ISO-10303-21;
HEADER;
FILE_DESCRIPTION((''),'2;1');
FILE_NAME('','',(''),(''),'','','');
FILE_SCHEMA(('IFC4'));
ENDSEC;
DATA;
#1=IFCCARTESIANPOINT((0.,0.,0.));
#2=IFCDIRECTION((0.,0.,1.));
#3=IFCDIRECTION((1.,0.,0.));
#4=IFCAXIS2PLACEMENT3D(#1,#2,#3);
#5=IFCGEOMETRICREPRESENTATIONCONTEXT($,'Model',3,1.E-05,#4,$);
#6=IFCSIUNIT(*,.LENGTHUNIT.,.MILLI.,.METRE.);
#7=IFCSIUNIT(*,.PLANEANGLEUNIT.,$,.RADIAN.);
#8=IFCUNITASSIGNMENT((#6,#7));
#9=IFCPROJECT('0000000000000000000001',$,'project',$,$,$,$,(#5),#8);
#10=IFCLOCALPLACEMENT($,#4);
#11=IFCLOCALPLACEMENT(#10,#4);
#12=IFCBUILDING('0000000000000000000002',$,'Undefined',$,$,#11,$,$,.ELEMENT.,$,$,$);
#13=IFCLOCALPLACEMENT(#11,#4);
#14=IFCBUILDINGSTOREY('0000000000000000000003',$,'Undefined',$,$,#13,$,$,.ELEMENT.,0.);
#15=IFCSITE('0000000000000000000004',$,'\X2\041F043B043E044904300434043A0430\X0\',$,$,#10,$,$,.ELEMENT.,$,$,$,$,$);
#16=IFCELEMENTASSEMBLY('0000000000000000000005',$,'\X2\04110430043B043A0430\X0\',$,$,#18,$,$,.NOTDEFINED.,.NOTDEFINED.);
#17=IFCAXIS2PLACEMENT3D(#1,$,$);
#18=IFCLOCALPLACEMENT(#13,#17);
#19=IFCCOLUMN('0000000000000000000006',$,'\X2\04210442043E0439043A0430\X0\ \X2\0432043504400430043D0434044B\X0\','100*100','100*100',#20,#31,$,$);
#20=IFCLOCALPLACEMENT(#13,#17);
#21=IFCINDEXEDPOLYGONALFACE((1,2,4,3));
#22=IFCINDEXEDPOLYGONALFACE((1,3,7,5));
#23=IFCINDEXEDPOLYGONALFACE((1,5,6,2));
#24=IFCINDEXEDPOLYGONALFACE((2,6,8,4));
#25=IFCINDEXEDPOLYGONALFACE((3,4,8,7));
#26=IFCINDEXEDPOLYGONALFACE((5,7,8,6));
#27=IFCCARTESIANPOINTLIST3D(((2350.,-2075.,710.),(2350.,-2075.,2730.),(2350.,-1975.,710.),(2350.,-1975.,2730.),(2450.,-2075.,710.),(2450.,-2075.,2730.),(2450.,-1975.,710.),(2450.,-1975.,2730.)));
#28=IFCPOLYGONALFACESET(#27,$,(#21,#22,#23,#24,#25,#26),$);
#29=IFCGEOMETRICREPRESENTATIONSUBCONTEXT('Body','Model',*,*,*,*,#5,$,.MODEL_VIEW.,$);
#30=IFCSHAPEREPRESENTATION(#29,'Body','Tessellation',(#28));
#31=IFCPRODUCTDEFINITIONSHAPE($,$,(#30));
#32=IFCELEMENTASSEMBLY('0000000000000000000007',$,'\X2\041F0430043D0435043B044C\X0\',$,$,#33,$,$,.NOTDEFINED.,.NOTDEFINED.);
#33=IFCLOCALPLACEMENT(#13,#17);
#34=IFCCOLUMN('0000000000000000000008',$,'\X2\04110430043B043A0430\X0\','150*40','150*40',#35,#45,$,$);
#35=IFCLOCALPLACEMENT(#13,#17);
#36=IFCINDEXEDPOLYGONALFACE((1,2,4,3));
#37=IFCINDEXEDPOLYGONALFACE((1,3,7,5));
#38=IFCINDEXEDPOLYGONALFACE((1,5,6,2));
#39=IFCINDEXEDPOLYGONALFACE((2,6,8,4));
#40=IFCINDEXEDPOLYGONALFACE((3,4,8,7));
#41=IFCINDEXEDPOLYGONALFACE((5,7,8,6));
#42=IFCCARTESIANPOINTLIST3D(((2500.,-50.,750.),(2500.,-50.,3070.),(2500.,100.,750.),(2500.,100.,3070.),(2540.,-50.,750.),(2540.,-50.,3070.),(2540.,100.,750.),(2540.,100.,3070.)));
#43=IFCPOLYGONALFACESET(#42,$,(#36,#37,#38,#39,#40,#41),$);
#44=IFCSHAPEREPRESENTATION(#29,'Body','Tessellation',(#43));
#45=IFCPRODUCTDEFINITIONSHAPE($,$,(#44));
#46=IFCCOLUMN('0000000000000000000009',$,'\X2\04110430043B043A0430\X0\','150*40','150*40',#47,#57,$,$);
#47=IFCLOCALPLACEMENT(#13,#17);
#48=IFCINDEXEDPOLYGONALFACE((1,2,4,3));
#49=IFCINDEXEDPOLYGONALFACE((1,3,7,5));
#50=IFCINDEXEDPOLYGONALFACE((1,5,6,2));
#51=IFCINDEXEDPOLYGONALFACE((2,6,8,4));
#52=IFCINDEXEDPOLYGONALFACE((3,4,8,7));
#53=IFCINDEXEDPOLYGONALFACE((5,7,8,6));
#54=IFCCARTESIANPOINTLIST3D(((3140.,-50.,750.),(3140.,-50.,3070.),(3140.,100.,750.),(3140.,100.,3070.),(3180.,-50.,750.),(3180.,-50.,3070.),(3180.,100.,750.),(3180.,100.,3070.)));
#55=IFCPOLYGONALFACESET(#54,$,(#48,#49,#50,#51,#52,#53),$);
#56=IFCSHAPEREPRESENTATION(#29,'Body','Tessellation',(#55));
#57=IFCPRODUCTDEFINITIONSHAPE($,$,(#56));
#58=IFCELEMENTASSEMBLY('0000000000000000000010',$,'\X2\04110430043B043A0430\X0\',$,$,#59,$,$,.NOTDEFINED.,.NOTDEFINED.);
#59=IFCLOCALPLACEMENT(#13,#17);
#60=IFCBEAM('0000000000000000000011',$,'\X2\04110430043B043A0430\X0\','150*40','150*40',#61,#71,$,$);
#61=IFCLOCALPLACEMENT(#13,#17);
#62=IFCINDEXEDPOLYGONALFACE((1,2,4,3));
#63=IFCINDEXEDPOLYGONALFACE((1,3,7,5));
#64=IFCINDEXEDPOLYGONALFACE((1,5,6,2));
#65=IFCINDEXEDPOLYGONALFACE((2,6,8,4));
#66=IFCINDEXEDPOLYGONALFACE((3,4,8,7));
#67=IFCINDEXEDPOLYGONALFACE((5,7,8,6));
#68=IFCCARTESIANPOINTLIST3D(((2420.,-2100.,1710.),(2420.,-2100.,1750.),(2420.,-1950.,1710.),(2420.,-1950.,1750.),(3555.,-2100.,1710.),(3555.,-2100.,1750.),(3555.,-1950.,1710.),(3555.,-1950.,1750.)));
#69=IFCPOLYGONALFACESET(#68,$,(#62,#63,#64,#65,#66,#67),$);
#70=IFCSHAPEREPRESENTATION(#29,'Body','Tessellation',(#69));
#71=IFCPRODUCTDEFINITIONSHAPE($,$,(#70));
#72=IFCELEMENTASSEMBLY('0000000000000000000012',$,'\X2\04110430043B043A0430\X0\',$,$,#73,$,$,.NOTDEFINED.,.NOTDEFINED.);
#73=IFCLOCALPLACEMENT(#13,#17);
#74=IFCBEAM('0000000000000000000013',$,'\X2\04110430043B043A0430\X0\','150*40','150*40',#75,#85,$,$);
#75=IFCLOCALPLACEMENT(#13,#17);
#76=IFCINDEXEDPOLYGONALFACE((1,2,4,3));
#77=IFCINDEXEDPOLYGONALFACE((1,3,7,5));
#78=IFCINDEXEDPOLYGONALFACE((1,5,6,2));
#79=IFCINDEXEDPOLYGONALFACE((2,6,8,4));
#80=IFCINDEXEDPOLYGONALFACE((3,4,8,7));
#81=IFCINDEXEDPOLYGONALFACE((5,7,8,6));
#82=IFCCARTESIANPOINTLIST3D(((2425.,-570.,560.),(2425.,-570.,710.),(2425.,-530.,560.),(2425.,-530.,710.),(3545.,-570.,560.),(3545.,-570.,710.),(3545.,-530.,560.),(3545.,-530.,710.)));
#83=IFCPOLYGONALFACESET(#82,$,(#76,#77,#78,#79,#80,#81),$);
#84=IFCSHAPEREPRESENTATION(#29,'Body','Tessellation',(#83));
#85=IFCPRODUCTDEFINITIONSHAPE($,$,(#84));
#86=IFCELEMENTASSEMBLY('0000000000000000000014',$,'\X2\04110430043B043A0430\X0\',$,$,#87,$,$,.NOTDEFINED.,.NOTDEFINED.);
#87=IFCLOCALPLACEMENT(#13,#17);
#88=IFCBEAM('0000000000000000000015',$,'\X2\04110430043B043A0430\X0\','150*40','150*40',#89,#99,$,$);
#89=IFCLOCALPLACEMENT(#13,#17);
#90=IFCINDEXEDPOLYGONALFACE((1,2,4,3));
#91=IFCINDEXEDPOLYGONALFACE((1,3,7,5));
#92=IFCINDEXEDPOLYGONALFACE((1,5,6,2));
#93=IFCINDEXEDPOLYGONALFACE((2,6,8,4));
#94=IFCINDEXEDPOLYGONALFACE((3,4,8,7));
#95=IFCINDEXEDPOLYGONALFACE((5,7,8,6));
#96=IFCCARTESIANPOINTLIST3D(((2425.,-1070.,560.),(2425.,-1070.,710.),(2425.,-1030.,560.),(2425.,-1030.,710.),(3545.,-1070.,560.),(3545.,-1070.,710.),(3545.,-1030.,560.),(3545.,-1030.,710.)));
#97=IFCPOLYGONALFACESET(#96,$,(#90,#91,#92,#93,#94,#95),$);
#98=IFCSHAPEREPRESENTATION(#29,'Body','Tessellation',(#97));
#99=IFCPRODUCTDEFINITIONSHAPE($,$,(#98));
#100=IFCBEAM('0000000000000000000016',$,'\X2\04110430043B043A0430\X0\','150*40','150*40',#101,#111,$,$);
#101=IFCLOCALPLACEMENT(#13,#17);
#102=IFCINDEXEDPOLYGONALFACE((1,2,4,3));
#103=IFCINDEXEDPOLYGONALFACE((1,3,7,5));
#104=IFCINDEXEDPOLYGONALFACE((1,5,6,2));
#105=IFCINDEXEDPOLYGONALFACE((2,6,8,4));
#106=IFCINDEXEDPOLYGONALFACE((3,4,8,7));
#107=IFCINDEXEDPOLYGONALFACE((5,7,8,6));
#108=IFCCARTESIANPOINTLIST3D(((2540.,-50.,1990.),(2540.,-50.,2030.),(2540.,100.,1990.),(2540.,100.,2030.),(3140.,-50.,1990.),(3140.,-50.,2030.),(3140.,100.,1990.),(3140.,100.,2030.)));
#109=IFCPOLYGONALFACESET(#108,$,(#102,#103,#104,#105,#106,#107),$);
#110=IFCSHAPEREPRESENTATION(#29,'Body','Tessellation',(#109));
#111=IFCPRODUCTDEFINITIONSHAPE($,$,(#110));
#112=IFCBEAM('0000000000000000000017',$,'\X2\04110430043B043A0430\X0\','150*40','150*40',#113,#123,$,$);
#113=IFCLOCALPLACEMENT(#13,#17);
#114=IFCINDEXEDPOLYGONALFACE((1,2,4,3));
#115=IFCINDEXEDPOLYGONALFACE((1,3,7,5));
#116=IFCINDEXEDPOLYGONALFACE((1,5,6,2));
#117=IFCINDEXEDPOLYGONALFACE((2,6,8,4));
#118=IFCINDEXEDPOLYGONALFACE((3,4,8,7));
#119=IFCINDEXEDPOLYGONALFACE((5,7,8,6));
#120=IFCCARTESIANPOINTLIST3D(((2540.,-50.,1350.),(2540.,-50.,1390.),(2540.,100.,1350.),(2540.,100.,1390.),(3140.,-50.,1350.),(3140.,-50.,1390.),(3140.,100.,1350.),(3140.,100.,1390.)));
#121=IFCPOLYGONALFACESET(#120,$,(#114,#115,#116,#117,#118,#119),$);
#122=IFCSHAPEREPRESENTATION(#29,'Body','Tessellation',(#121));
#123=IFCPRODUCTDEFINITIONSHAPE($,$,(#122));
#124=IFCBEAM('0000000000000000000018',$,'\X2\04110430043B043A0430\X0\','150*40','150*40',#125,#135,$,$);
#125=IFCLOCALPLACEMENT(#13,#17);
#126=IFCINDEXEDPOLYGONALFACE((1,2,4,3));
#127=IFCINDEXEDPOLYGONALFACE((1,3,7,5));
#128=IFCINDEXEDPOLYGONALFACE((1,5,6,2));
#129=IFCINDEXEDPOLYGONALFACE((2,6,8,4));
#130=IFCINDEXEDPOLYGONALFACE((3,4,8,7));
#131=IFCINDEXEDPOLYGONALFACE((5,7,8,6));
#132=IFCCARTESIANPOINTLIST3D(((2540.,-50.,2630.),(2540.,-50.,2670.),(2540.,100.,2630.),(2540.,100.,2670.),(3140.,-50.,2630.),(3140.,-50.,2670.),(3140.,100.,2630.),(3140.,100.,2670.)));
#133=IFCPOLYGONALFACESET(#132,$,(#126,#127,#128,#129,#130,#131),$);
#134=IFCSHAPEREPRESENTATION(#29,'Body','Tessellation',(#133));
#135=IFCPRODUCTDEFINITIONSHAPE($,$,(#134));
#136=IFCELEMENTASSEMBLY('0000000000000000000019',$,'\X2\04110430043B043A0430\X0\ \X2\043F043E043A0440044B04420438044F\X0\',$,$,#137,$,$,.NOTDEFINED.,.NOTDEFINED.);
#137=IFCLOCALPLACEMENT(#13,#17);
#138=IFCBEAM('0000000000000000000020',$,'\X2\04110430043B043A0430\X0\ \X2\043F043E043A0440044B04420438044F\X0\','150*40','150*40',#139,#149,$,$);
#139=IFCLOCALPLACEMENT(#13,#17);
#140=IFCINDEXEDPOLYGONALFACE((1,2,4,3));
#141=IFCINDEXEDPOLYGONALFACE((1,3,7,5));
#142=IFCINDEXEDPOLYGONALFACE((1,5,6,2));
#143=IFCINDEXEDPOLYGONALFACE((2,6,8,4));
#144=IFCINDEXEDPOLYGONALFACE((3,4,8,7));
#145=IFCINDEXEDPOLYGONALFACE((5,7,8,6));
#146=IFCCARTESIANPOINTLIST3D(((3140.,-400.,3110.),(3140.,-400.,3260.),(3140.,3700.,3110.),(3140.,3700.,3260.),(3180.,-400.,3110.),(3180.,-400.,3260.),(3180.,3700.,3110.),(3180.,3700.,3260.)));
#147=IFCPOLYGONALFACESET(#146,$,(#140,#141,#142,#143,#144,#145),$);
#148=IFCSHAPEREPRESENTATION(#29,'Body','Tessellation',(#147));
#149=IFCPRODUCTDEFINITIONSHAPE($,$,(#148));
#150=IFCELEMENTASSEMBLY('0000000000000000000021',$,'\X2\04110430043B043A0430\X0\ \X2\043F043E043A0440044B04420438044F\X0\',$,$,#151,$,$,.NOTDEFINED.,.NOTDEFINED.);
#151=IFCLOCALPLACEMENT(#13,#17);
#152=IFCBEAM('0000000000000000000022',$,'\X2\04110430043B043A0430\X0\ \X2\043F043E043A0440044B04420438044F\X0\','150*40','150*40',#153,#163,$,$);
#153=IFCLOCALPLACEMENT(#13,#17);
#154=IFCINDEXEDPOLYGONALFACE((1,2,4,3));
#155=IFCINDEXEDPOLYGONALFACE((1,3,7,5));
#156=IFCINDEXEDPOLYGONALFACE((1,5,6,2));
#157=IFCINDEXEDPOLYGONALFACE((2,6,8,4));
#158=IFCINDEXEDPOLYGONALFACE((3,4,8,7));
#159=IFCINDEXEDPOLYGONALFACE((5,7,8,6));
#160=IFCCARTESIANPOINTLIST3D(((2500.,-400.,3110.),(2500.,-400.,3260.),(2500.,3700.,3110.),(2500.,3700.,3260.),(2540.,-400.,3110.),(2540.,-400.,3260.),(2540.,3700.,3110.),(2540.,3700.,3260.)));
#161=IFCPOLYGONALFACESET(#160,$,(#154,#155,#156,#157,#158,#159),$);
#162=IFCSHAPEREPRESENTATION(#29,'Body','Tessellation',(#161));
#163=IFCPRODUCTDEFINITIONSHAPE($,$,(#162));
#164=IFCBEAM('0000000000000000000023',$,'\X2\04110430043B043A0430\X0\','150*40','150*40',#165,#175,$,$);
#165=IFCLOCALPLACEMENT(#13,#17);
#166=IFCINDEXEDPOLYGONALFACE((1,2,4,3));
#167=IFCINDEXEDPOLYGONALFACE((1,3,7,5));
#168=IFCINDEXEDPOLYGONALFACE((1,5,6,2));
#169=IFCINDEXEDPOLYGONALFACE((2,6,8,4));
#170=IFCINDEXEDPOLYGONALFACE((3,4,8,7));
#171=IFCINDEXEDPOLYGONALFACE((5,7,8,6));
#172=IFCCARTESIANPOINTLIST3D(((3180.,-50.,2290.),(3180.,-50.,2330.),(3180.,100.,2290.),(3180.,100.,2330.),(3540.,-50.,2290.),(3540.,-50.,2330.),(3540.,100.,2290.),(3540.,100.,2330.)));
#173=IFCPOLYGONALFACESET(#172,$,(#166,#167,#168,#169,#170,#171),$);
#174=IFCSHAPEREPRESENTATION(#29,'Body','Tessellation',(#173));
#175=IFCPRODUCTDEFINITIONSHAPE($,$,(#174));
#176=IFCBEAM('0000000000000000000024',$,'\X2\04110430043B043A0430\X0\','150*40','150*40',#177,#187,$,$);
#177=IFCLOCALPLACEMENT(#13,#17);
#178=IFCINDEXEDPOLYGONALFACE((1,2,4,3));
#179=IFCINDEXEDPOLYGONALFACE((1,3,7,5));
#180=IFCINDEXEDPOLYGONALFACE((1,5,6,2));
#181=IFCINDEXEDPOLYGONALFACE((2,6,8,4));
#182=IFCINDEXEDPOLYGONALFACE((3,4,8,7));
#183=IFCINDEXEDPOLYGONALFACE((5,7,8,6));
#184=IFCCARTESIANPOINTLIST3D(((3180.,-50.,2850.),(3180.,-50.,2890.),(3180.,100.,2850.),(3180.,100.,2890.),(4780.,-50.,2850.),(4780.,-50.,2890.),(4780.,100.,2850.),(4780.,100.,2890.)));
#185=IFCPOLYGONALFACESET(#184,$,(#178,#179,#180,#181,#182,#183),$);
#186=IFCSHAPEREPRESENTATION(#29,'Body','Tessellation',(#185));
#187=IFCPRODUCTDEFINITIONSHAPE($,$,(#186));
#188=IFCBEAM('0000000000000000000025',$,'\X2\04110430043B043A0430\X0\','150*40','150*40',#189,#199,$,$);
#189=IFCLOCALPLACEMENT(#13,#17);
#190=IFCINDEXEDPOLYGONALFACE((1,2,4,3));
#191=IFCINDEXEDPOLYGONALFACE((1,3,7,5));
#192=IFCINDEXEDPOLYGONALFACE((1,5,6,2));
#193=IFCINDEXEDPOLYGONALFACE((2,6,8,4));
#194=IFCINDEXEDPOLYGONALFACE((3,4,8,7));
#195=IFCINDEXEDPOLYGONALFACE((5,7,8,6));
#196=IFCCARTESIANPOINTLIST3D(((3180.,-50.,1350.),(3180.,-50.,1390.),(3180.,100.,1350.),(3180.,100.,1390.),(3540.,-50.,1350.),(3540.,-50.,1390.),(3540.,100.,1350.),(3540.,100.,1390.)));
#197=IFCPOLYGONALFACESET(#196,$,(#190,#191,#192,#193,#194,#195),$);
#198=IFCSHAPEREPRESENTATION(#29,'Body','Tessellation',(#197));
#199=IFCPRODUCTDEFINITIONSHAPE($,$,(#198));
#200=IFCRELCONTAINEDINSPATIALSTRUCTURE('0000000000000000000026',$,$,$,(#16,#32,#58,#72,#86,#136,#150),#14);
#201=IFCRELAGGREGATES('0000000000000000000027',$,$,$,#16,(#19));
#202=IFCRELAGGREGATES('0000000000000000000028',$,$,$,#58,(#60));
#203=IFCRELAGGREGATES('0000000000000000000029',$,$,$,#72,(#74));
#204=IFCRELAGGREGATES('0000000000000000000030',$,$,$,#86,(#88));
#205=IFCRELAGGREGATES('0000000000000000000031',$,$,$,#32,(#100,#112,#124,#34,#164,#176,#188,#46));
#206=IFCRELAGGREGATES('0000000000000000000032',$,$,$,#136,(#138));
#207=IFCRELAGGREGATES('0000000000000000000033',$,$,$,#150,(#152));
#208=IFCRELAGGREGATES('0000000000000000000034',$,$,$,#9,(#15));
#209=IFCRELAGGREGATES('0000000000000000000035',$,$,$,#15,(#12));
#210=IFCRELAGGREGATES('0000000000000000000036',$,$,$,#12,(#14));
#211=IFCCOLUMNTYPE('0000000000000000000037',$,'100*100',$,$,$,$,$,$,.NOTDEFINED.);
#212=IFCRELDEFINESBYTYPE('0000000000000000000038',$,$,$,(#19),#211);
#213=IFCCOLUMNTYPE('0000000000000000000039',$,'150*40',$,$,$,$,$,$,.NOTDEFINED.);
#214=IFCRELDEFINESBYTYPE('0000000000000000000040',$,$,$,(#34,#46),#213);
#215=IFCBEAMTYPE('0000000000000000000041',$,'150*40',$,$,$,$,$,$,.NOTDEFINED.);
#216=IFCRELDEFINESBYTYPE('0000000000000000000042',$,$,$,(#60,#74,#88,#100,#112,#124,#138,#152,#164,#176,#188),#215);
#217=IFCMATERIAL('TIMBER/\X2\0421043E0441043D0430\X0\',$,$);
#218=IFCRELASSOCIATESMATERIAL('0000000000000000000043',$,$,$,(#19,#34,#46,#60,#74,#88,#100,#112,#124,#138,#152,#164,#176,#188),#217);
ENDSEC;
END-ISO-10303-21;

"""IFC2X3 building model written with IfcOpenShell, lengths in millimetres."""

from ifc_helpers import new_model, si_unit, frame, origin_with_axes, origin_2d_with_axis, place, context, subcontext, project, spatial, rectangle, extrude, material, type_object, element, aggregate, save


model = new_model("IFC2X3")

# Units and contexts
model_context = context("Model", 3, precision=1e-05, world=origin_with_axes())
body_context = subcontext(model_context, "Body", "Model", "MODEL_VIEW")
ifc_project = project(units=[si_unit("LENGTHUNIT", "METRE", prefix="MILLI"), si_unit("PLANEANGLEUNIT", "RADIAN")], contexts=[model_context])

# Site, building, storey
site_placement = place(None, origin_with_axes())
site = spatial("IfcSite", under=ifc_project, at=site_placement, Name="Площадка", CompositionType="ELEMENT")
building_placement = place(site_placement, origin_with_axes())
building = spatial("IfcBuilding", under=site, at=building_placement, Name="Undefined", CompositionType="ELEMENT")
storey_placement = place(building_placement, origin_with_axes())
storey = spatial("IfcBuildingStorey", under=building, at=storey_placement, Name="Undefined", CompositionType="ELEMENT", Elevation=0.0)

# Element assembly, column
assembly_1_placement = place(storey_placement, origin_with_axes())
assembly_1 = element("IfcElementAssembly", 1, at=assembly_1_placement, inside=storey, Name="Балка", AssemblyPlace="NOTDEFINED", PredefinedType="NOTDEFINED")
ifc_material_1 = material(Name="TIMBER/Сосна")
column_type_1 = type_object("IfcColumnType", Name="100*100", PredefinedType="NOTDEFINED")
column_1_placement = place(assembly_1_placement, frame((2400.0, -2025.0, 710.0), z_axis=(0.0, 0.0, 1.0), x_axis=(0.0, 1.0, 0.0)))
column_1 = element("IfcColumn", 2, at=column_1_placement, type_object=column_type_1, material=ifc_material_1, Name="Стойка веранды", Description="100*100", ObjectType="100*100", context=body_context, shape_type="SweptSolid", body=[
    extrude(rectangle(XDim=100.0, YDim=100.0, at=origin_2d_with_axis()), frame((0.0, 0.0, 2020.0), z_axis=(0.0, 0.0, -1.0), x_axis=(0.0, 1.0, 0.0)), (0.0, 0.0, 1.0), 2020.0),
])
aggregate(assembly_1, [column_1])

# Element assembly, columns
assembly_2_placement = place(storey_placement, origin_with_axes())
assembly_2 = element("IfcElementAssembly", 3, at=assembly_2_placement, inside=storey, Name="Панель", AssemblyPlace="NOTDEFINED", PredefinedType="NOTDEFINED")
column_type_2 = type_object("IfcColumnType", Name="150*40", PredefinedType="NOTDEFINED")
column_2_placement = place(assembly_2_placement, frame((2520.0, 25.0, 750.0), z_axis=(0.0, 0.0, 1.0), x_axis=(0.0, 1.0, 0.0)))
column_2 = element("IfcColumn", 4, at=column_2_placement, type_object=column_type_2, material=ifc_material_1, Name="Балка", Description="150*40", ObjectType="150*40", context=body_context, shape_type="SweptSolid", body=[
    extrude(rectangle(XDim=40.0, YDim=150.0, at=origin_2d_with_axis()), frame((0.0, 0.0, 2320.0), z_axis=(0.0, 0.0, -1.0), x_axis=(0.0, 1.0, 0.0)), (0.0, 0.0, 1.0), 2320.0),
])
column_3_placement = place(assembly_2_placement, frame((3160.0, 25.0, 750.0), z_axis=(0.0, 0.0, 1.0), x_axis=(0.0, 1.0, 0.0)))
column_3 = element("IfcColumn", 5, at=column_3_placement, type_object=column_type_2, material=ifc_material_1, Name="Балка", Description="150*40", ObjectType="150*40", context=body_context, shape_type="SweptSolid", body=[
    extrude(rectangle(XDim=40.0, YDim=150.0, at=origin_2d_with_axis()), frame((0.0, 0.0, 2320.0), z_axis=(0.0, 0.0, -1.0), x_axis=(0.0, 1.0, 0.0)), (0.0, 0.0, 1.0), 2320.0),
])

# Element assemblies, beams
assembly_3_placement = place(storey_placement, origin_with_axes())
assembly_3 = element("IfcElementAssembly", 6, at=assembly_3_placement, inside=storey, Name="Балка", AssemblyPlace="NOTDEFINED", PredefinedType="NOTDEFINED")
beam_type = type_object("IfcBeamType", Name="150*40", PredefinedType="NOTDEFINED")
beam_1_placement = place(assembly_3_placement, frame((2420.0, -2025.0, 1730.0), z_axis=(0.0, 1.0, 0.0), x_axis=(1.0, 0.0, 0.0)))
beam_1 = element("IfcBeam", 7, at=beam_1_placement, type_object=beam_type, material=ifc_material_1, Name="Балка", Description="150*40", ObjectType="150*40", context=body_context, shape_type="SweptSolid", body=[
    extrude(rectangle(XDim=40.0, YDim=150.0, at=origin_2d_with_axis()), frame((1135.0, 0.0, 0.0), z_axis=(-1.0, 0.0, 0.0), x_axis=(0.0, -1.0, 0.0)), (0.0, 0.0, 1.0), 1135.0),
])
aggregate(assembly_3, [beam_1])
assembly_4_placement = place(storey_placement, origin_with_axes())
assembly_4 = element("IfcElementAssembly", 8, at=assembly_4_placement, inside=storey, Name="Балка", AssemblyPlace="NOTDEFINED", PredefinedType="NOTDEFINED")
beam_2_placement = place(assembly_4_placement, frame((3545.0, -550.0, 635.0), z_axis=(0.0, 0.0, -1.0), x_axis=(-1.0, 0.0, 0.0)))
beam_2 = element("IfcBeam", 9, at=beam_2_placement, type_object=beam_type, material=ifc_material_1, Name="Балка", Description="150*40", ObjectType="150*40", context=body_context, shape_type="SweptSolid", body=[
    extrude(rectangle(XDim=40.0, YDim=150.0, at=origin_2d_with_axis()), frame((1120.0, 0.0, 0.0), z_axis=(-1.0, 0.0, 0.0), x_axis=(0.0, -1.0, 0.0)), (0.0, 0.0, 1.0), 1120.0),
])
aggregate(assembly_4, [beam_2])
assembly_5_placement = place(storey_placement, origin_with_axes())
assembly_5 = element("IfcElementAssembly", 10, at=assembly_5_placement, inside=storey, Name="Балка", AssemblyPlace="NOTDEFINED", PredefinedType="NOTDEFINED")
beam_3_placement = place(assembly_5_placement, frame((3545.0, -1050.0, 635.0), z_axis=(0.0, 0.0, -1.0), x_axis=(-1.0, 0.0, 0.0)))
beam_3 = element("IfcBeam", 11, at=beam_3_placement, type_object=beam_type, material=ifc_material_1, Name="Балка", Description="150*40", ObjectType="150*40", context=body_context, shape_type="SweptSolid", body=[
    extrude(rectangle(XDim=40.0, YDim=150.0, at=origin_2d_with_axis()), frame((1120.0, 0.0, 0.0), z_axis=(-1.0, 0.0, 0.0), x_axis=(0.0, -1.0, 0.0)), (0.0, 0.0, 1.0), 1120.0),
])
aggregate(assembly_5, [beam_3])

# Beams
beam_4_placement = place(assembly_2_placement, frame((2540.0, 25.0, 2010.0), z_axis=(0.0, 1.0, 0.0), x_axis=(1.0, 0.0, 0.0)))
beam_4 = element("IfcBeam", 12, at=beam_4_placement, type_object=beam_type, material=ifc_material_1, Name="Балка", Description="150*40", ObjectType="150*40", context=body_context, shape_type="SweptSolid", body=[
    extrude(rectangle(XDim=40.0, YDim=150.0, at=origin_2d_with_axis()), frame((600.0, 0.0, 0.0), z_axis=(-1.0, 0.0, 0.0), x_axis=(0.0, -1.0, 0.0)), (0.0, 0.0, 1.0), 600.0),
])
beam_5_placement = place(assembly_2_placement, frame((2540.0, 25.0, 1370.0), z_axis=(0.0, 1.0, 0.0), x_axis=(1.0, 0.0, 0.0)))
beam_5 = element("IfcBeam", 13, at=beam_5_placement, type_object=beam_type, material=ifc_material_1, Name="Балка", Description="150*40", ObjectType="150*40", context=body_context, shape_type="SweptSolid", body=[
    extrude(rectangle(XDim=40.0, YDim=150.0, at=origin_2d_with_axis()), frame((600.0, 0.0, 0.0), z_axis=(-1.0, 0.0, 0.0), x_axis=(0.0, -1.0, 0.0)), (0.0, 0.0, 1.0), 600.0),
])
beam_6_placement = place(assembly_2_placement, frame((2540.0, 25.0, 2650.0), z_axis=(0.0, 1.0, 0.0), x_axis=(1.0, 0.0, 0.0)))
beam_6 = element("IfcBeam", 14, at=beam_6_placement, type_object=beam_type, material=ifc_material_1, Name="Балка", Description="150*40", ObjectType="150*40", context=body_context, shape_type="SweptSolid", body=[
    extrude(rectangle(XDim=40.0, YDim=150.0, at=origin_2d_with_axis()), frame((600.0, 0.0, 0.0), z_axis=(-1.0, 0.0, 0.0), x_axis=(0.0, -1.0, 0.0)), (0.0, 0.0, 1.0), 600.0),
])

# Element assemblies, beams
assembly_6_placement = place(storey_placement, origin_with_axes())
assembly_6 = element("IfcElementAssembly", 15, at=assembly_6_placement, inside=storey, Name="Балка покрытия", AssemblyPlace="NOTDEFINED", PredefinedType="NOTDEFINED")
beam_7_placement = place(assembly_6_placement, frame((3160.0, -400.0, 3185.0), z_axis=(0.0, 0.0, -1.0), x_axis=(0.0, 1.0, 0.0)))
beam_7 = element("IfcBeam", 16, at=beam_7_placement, type_object=beam_type, material=ifc_material_1, Name="Балка покрытия", Description="150*40", ObjectType="150*40", context=body_context, shape_type="SweptSolid", body=[
    extrude(rectangle(XDim=40.0, YDim=150.0, at=origin_2d_with_axis()), frame((4100.0, 0.0, 0.0), z_axis=(-1.0, 0.0, 0.0), x_axis=(0.0, -1.0, 0.0)), (0.0, 0.0, 1.0), 4100.0),
])
assembly_7_placement = place(storey_placement, origin_with_axes())
assembly_7 = element("IfcElementAssembly", 17, at=assembly_7_placement, inside=storey, Name="Балка покрытия", AssemblyPlace="NOTDEFINED", PredefinedType="NOTDEFINED")
beam_8_placement = place(assembly_7_placement, frame((2520.0, -400.0, 3185.0), z_axis=(0.0, 0.0, -1.0), x_axis=(0.0, 1.0, 0.0)))
beam_8 = element("IfcBeam", 18, at=beam_8_placement, type_object=beam_type, material=ifc_material_1, Name="Балка покрытия", Description="150*40", ObjectType="150*40", context=body_context, shape_type="SweptSolid", body=[
    extrude(rectangle(XDim=40.0, YDim=150.0, at=origin_2d_with_axis()), frame((4100.0, 0.0, 0.0), z_axis=(-1.0, 0.0, 0.0), x_axis=(0.0, -1.0, 0.0)), (0.0, 0.0, 1.0), 4100.0),
])

# Beams
beam_9_placement = place(assembly_2_placement, frame((3180.0, 25.0, 2310.0), z_axis=(0.0, 1.0, 0.0), x_axis=(1.0, 0.0, 0.0)))
beam_9 = element("IfcBeam", 19, at=beam_9_placement, type_object=beam_type, material=ifc_material_1, Name="Балка", Description="150*40", ObjectType="150*40", context=body_context, shape_type="SweptSolid", body=[
    extrude(rectangle(XDim=40.0, YDim=150.0, at=origin_2d_with_axis()), frame((360.0, 0.0, 0.0), z_axis=(-1.0, 0.0, 0.0), x_axis=(0.0, -1.0, 0.0)), (0.0, 0.0, 1.0), 360.0),
])
beam_10_placement = place(assembly_2_placement, frame((3180.0, 25.0, 2870.0), z_axis=(0.0, 1.0, 0.0), x_axis=(1.0, 0.0, 0.0)))
beam_10 = element("IfcBeam", 20, at=beam_10_placement, type_object=beam_type, material=ifc_material_1, Name="Балка", Description="150*40", ObjectType="150*40", context=body_context, shape_type="SweptSolid", body=[
    extrude(rectangle(XDim=40.0, YDim=150.0, at=origin_2d_with_axis()), frame((1600.0, 0.0, 0.0), z_axis=(-1.0, 0.0, 0.0), x_axis=(0.0, -1.0, 0.0)), (0.0, 0.0, 1.0), 1600.0),
])
beam_11_placement = place(assembly_2_placement, frame((3180.0, 25.0, 1370.0), z_axis=(0.0, 1.0, 0.0), x_axis=(1.0, 0.0, 0.0)))
beam_11 = element("IfcBeam", 21, at=beam_11_placement, type_object=beam_type, material=ifc_material_1, Name="Балка", Description="150*40", ObjectType="150*40", context=body_context, shape_type="SweptSolid", body=[
    extrude(rectangle(XDim=40.0, YDim=150.0, at=origin_2d_with_axis()), frame((360.0, 0.0, 0.0), z_axis=(-1.0, 0.0, 0.0), x_axis=(0.0, -1.0, 0.0)), (0.0, 0.0, 1.0), 360.0),
])
aggregate(assembly_2, [beam_4, beam_5, beam_6, column_2, beam_9, beam_10, beam_11, column_3])

aggregate(assembly_6, [beam_7])
aggregate(assembly_7, [beam_8])

save(model, "model.ifc")
